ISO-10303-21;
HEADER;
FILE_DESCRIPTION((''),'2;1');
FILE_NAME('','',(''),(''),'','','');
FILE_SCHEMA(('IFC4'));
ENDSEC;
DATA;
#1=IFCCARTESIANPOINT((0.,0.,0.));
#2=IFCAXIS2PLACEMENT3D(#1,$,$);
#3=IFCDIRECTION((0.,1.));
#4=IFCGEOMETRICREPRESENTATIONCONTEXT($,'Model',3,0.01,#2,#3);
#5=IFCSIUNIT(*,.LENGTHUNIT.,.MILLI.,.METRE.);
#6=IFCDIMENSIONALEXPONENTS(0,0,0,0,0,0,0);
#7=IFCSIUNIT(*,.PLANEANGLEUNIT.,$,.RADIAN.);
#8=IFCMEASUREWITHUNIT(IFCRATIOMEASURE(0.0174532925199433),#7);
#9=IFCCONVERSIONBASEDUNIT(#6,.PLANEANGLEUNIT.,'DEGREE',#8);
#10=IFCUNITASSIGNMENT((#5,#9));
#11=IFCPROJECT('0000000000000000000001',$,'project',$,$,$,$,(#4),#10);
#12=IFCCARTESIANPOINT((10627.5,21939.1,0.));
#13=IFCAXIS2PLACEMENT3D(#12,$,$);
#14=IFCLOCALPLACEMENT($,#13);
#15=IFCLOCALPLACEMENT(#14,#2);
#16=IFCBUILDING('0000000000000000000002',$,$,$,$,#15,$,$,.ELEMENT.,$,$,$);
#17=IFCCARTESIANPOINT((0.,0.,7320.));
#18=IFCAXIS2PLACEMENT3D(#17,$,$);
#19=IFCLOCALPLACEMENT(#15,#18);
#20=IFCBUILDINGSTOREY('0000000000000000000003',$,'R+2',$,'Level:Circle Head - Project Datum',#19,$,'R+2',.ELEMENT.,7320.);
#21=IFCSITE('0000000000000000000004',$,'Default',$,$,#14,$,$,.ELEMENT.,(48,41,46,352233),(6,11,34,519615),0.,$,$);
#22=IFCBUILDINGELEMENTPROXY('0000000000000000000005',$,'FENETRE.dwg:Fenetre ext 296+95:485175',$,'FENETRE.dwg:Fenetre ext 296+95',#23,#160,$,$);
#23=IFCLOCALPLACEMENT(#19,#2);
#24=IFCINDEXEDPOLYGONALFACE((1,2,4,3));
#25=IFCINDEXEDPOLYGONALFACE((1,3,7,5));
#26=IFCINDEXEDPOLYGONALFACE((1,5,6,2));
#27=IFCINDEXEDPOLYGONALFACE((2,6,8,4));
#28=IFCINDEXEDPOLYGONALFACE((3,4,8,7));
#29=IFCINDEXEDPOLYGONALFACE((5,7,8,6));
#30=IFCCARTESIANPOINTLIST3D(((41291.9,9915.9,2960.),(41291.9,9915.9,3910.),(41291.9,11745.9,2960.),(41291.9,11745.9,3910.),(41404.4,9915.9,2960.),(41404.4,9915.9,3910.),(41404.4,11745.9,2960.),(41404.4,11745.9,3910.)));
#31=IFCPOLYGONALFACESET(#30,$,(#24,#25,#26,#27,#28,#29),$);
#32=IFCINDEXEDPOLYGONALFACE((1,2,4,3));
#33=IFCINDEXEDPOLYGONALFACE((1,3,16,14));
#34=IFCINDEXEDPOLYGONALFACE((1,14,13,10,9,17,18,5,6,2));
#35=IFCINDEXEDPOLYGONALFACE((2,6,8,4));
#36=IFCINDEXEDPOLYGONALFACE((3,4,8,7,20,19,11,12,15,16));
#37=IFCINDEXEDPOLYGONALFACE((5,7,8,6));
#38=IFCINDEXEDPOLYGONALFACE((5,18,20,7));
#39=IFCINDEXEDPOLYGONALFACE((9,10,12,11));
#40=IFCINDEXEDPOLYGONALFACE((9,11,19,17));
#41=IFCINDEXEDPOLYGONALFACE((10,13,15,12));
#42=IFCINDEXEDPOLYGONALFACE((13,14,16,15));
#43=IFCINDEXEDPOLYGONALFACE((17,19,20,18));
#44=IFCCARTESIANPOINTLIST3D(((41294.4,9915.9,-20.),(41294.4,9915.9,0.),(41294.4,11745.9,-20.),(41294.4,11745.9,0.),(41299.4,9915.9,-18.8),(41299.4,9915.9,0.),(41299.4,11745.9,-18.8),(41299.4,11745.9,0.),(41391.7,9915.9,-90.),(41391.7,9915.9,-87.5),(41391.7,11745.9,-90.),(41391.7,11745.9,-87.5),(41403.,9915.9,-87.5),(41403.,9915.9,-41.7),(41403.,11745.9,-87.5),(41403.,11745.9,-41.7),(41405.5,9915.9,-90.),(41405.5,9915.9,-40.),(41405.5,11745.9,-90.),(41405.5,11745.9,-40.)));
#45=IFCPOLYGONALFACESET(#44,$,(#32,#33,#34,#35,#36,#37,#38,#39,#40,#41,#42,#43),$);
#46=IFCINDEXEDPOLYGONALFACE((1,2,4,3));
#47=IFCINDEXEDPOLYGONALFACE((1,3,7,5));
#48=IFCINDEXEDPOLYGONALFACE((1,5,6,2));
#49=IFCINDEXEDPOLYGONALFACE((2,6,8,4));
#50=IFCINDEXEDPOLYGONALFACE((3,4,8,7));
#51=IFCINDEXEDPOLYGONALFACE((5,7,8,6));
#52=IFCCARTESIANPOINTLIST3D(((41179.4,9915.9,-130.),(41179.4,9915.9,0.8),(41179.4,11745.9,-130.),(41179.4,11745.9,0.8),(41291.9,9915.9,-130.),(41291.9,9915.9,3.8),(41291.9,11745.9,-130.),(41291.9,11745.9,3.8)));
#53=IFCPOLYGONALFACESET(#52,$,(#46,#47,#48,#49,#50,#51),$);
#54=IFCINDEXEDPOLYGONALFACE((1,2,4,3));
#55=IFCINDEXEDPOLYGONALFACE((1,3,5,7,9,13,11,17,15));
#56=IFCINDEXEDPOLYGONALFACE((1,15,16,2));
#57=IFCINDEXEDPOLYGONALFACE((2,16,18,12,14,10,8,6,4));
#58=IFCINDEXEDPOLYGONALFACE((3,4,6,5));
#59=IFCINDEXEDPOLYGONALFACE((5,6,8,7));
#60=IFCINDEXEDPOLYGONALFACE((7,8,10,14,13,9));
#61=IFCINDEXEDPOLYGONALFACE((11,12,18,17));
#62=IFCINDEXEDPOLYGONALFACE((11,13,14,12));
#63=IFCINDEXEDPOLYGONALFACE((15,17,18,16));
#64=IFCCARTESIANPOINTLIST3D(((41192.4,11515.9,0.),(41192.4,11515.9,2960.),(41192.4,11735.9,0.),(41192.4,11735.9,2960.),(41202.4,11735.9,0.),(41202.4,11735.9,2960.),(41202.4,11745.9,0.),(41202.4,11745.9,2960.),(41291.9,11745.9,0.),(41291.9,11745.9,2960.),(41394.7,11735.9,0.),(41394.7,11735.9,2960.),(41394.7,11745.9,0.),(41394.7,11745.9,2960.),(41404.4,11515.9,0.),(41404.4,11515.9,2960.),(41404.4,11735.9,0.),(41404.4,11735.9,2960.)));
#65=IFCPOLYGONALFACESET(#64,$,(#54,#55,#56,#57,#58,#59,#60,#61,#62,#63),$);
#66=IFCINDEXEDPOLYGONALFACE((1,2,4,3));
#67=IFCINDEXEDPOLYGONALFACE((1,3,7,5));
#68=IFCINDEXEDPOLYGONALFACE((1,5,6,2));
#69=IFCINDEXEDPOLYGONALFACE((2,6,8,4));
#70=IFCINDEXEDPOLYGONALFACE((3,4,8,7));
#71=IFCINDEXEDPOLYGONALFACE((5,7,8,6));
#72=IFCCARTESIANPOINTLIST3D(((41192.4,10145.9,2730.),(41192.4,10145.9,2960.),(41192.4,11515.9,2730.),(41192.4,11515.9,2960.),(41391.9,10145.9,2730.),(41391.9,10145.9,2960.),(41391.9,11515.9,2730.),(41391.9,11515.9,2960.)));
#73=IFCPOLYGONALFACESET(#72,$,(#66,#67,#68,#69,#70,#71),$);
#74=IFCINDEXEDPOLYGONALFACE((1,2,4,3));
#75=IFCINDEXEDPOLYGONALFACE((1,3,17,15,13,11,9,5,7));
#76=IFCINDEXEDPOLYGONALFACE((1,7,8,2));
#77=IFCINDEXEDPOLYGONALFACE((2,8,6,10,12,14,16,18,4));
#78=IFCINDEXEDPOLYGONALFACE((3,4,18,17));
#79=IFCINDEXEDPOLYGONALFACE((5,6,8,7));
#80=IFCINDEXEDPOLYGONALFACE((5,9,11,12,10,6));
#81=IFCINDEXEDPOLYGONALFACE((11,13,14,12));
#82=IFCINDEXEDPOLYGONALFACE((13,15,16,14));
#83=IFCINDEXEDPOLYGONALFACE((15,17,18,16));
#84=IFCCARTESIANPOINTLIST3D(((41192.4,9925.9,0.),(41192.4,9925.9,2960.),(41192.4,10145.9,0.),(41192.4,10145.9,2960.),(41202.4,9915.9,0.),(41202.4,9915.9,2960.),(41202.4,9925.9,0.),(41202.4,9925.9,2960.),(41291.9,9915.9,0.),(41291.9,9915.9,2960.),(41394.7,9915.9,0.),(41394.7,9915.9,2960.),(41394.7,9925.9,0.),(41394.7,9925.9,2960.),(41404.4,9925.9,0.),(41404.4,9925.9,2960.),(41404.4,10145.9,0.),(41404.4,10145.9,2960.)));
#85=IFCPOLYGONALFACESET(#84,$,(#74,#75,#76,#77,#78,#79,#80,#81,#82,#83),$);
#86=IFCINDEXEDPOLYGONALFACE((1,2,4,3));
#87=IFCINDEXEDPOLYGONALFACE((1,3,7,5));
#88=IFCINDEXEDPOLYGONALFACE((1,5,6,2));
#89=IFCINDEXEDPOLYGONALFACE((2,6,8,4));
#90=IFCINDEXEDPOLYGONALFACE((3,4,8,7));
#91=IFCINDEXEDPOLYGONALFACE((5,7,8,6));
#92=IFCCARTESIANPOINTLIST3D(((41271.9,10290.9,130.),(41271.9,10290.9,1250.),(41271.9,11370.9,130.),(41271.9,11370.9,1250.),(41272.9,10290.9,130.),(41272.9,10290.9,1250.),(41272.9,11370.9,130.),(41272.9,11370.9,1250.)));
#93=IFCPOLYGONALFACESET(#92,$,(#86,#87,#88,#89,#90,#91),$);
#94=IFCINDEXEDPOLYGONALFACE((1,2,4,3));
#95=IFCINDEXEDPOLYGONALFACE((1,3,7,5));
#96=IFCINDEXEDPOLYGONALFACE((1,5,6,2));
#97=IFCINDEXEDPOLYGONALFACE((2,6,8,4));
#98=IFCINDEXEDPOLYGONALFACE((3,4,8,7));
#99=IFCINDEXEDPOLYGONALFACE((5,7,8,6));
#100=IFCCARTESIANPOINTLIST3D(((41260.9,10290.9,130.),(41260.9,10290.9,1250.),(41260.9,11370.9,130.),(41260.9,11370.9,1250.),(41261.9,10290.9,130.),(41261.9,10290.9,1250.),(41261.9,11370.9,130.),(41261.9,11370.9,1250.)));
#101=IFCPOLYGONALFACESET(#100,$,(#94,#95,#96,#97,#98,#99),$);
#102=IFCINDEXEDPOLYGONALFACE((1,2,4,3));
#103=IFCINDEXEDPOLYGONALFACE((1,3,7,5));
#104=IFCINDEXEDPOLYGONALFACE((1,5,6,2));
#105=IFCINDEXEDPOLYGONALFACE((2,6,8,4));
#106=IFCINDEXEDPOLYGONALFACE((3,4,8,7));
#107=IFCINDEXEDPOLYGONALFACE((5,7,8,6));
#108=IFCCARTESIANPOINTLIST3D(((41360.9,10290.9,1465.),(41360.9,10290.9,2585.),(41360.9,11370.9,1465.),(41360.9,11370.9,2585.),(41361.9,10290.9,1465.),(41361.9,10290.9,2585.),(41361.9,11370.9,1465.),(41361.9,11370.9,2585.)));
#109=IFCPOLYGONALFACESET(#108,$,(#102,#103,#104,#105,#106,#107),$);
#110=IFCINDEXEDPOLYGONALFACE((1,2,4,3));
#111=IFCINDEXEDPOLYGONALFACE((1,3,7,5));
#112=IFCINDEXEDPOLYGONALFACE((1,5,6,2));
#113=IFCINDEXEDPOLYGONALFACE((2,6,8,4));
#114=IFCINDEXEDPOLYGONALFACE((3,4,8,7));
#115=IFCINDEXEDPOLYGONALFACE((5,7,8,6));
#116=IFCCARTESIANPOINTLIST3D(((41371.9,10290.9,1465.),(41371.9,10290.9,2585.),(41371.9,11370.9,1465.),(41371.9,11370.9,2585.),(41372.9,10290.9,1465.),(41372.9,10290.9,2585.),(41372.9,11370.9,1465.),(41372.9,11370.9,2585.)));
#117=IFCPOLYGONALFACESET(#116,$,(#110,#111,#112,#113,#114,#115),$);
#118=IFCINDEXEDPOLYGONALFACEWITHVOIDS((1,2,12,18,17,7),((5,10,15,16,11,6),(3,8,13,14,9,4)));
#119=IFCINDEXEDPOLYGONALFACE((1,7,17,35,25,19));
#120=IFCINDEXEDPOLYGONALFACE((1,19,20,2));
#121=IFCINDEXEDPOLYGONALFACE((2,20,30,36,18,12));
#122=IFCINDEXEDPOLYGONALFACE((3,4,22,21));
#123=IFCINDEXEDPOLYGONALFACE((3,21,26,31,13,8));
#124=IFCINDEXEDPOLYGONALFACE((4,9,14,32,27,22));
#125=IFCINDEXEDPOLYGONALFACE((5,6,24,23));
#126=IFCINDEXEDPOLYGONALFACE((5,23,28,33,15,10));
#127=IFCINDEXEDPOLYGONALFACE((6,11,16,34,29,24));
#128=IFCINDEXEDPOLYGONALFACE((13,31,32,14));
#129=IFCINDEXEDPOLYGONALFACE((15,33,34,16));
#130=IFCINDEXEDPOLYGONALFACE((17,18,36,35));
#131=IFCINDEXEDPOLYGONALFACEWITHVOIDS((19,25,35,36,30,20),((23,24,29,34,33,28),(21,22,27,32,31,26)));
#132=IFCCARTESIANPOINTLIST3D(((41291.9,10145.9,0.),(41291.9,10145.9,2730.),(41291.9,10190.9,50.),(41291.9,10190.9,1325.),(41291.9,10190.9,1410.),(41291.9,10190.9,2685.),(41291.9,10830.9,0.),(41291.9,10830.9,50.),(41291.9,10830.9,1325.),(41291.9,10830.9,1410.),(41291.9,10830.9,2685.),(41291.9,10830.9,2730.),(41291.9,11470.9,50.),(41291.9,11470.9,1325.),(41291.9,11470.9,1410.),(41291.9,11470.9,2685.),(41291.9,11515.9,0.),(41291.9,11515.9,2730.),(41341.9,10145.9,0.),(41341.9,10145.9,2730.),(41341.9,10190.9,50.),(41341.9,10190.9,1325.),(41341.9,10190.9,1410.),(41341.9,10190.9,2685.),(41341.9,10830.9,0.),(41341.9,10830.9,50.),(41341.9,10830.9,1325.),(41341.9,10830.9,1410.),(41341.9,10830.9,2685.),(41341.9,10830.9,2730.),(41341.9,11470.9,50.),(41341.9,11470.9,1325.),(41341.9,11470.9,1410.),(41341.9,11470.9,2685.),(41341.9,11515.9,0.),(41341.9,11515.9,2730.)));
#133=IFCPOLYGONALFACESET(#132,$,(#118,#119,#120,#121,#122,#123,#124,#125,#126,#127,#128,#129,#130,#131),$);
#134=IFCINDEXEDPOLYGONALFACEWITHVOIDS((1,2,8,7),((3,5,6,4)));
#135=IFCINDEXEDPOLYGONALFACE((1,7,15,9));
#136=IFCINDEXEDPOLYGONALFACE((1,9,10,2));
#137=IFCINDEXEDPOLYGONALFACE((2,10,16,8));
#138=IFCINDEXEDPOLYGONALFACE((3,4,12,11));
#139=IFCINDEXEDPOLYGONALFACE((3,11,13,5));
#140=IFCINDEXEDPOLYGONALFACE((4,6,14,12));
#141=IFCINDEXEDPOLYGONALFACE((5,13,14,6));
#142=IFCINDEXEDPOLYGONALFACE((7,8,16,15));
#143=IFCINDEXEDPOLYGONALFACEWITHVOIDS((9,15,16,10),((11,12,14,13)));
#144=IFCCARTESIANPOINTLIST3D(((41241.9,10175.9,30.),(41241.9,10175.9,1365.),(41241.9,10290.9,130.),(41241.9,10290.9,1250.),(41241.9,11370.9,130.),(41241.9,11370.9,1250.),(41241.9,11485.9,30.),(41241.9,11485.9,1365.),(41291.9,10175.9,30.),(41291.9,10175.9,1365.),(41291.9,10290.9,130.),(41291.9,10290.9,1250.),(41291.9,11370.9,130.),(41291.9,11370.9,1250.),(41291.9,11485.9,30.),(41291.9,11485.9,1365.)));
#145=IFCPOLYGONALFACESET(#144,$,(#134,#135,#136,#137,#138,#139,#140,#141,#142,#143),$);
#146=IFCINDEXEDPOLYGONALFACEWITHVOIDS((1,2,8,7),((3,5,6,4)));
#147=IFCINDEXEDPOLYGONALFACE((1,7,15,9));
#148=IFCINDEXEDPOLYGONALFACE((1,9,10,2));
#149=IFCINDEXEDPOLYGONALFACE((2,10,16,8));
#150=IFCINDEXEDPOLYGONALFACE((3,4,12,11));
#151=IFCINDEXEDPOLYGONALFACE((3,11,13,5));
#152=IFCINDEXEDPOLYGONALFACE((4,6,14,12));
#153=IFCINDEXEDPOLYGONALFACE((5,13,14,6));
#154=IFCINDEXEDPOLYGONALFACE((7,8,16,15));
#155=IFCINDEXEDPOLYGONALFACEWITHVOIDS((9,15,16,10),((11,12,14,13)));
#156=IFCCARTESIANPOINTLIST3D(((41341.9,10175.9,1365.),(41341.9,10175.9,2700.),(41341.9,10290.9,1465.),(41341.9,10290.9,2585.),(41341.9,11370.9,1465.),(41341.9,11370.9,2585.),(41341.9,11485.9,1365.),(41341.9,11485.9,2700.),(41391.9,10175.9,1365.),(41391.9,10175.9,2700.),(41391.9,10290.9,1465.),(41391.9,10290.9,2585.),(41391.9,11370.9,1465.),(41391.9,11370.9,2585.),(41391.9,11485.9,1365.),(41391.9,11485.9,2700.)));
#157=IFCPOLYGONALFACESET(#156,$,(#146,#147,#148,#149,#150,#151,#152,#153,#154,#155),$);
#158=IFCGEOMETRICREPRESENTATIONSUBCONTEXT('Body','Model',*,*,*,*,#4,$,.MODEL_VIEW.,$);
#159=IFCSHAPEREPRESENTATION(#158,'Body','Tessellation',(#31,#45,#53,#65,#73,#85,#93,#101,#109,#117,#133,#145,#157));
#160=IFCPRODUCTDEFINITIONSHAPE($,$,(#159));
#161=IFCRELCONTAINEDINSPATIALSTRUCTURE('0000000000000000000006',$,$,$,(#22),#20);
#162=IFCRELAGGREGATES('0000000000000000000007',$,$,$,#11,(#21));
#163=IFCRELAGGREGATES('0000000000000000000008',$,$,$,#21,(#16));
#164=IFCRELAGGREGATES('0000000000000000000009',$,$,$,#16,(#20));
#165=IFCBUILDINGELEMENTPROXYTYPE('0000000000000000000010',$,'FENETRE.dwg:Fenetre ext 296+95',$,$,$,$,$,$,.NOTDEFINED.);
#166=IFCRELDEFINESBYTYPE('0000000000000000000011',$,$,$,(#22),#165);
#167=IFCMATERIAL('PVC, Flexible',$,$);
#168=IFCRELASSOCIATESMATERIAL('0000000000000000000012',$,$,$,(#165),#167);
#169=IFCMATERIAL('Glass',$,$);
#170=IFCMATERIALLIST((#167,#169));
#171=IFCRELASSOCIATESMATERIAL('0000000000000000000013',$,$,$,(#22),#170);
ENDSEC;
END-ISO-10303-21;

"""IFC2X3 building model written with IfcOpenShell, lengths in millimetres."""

from ifc_helpers import new_model, entity, si_unit, converted_unit, direction, frame, frame_2d, origin, origin_2d_with_axis, place, context, subcontext, project, spatial, polyline, rectangle, outline, extrude, source, transform, mapped, material, material_list, type_object, type_shapes, element, save


model = new_model("IFC2X3")

# Units and contexts
model_context = context("Model", 3, precision=0.01, world=origin(), true_north=direction((0.0, 1.0)))
body_context = subcontext(model_context, "Body", "Model", "MODEL_VIEW")
ifc_project = project(units=[si_unit("LENGTHUNIT", "METRE", prefix="MILLI"), converted_unit("PLANEANGLEUNIT", "DEGREE", entity("IfcRatioMeasure", 0.0174532925199433), si_unit("PLANEANGLEUNIT", "RADIAN"), dimensions=[0, 0, 0, 0, 0, 0, 0])], contexts=[model_context])

# Site, building, storey
site_placement = place(None, frame((10627.5, 21939.1, 0.0)))
site = spatial("IfcSite", under=ifc_project, at=site_placement, Name="Default", CompositionType="ELEMENT", RefLatitude=(48, 41, 46, 352233), RefLongitude=(6, 11, 34, 519615), RefElevation=0.0)
building_placement = place(site_placement, origin())
building = spatial("IfcBuilding", under=site, at=building_placement, CompositionType="ELEMENT")
storey_placement = place(building_placement, frame((0.0, 0.0, 7320.0)))
storey = spatial("IfcBuildingStorey", under=building, at=storey_placement, Name="R+2", ObjectType="Level:Circle Head - Project Datum", LongName="R+2", CompositionType="ELEMENT", Elevation=7320.0)

# Building element proxy
ifc_material_1 = material(Name="PVC, Flexible")
ifc_material_2 = material(Name="Glass")
building_element_proxy_type_1 = type_object("IfcBuildingElementProxyType", Name="FENETRE.dwg:Fenetre ext 296+95", PredefinedType="NOTDEFINED", material=ifc_material_1)
shared_shape_1 = source(origin(), body_context, "Body", "SweptSolid", [
    extrude(rectangle(XDim=112.5, YDim=1830.0, at=origin_2d_with_axis()), frame((-10.4, -56.3, 2960.0), z_axis=(0.0, 0.0, 1.0), x_axis=(0.0, 1.0, 0.0)), (0.0, 0.0, 1.0), 950.0),
    extrude(outline(polyline([(27.5, -64.4), (47.5, -64.4), (47.5, -59.4), (28.8, -59.4), (7.5, 46.7), (-42.5, 46.7), (-42.5, 32.9), (-40.0, 32.9), (-40.0, 44.2), (5.8, 44.2), (27.5, -64.4)])), frame((-925.4, -66.9, -47.5), z_axis=(1.0, 0.0, 0.0), x_axis=(0.0, 0.0, 1.0)), (0.0, 0.0, 1.0), 1830.0),
    extrude(outline(polyline([(-54.5, -66.1), (58.0, -66.1), (54.5, 67.6), (-58.0, 64.6), (-54.5, -66.1)])), frame((-925.4, 56.3, -63.8), z_axis=(1.0, 0.0, 0.0), x_axis=(0.0, -0.999645, 0.02665)), (0.0, 0.0, 1.0), 1830.0),
    extrude(outline(polyline([(-97.0, -55.6), (5.9, -55.6), (95.4, -55.6), (95.4, -45.6), (105.4, -45.6), (105.4, 174.4), (-106.6, 174.4), (-106.6, -45.6), (-97.0, -45.6), (-97.0, -55.6)])), frame((849.0, -5.9, 0.0), z_axis=(0.0, 0.0, 1.0), x_axis=(0.0, 1.0, 0.0)), (0.0, 0.0, 1.0), 2960.0),
    extrude(rectangle(XDim=1370.0, YDim=199.5, at=origin_2d_with_axis()), frame((-10.4, -0.3, 2730.0), z_axis=(0.0, 0.0, 1.0), x_axis=(-1.0, 0.0, 0.0)), (0.0, 0.0, 1.0), 230.0),
    extrude(outline(polyline([(-55.6, 97.0), (-55.6, -5.9), (-55.6, -95.4), (-45.6, -95.4), (-45.6, -105.4), (174.4, -105.4), (174.4, 106.6), (-45.6, 106.6), (-45.6, 97.0), (-55.6, 97.0)])), frame((-869.9, -5.9, 0.0), z_axis=(0.0, 0.0, -1.0), x_axis=(1.0, 0.0, 0.0)), (0.0, 0.0, -1.0), 2960.0),
    extrude(rectangle(XDim=1080.0, YDim=1.0, at=origin_2d_with_axis()), frame((-10.4, 19.5, 130.0), z_axis=(0.0, 0.0, 1.0), x_axis=(-1.0, 0.0, 0.0)), (0.0, 0.0, 1.0), 1120.0),
    extrude(rectangle(XDim=1080.0, YDim=1.0, at=origin_2d_with_axis()), frame((-10.4, 30.5, 130.0), z_axis=(0.0, 0.0, 1.0), x_axis=(-1.0, 0.0, 0.0)), (0.0, 0.0, 1.0), 1120.0),
    extrude(rectangle(XDim=1080.0, YDim=1.0, at=frame_2d((0.0, 0.0), x_axis=(1.0, 0.0))), frame((-10.4, -69.5, 1465.0), z_axis=(0.0, 0.0, 1.0), x_axis=(-1.0, 0.0, 0.0)), (0.0, 0.0, 1.0), 1120.0),
    extrude(rectangle(XDim=1080.0, YDim=1.0, at=frame_2d((0.0, 0.0), x_axis=(1.0, 0.0))), frame((-10.4, -80.5, 1465.0), z_axis=(0.0, 0.0, 1.0), x_axis=(-1.0, 0.0, 0.0)), (0.0, 0.0, 1.0), 1120.0),
    extrude(outline(polyline([(-685.0, -1365.0), (0.0, -1365.0), (685.0, -1365.0), (685.0, 1365.0), (0.0, 1365.0), (-685.0, 1365.0), (-685.0, -1365.0)]), holes=[polyline([(-640.0, -1320.0), (-640.0, -45.0), (0.0, -45.0), (640.0, -45.0), (640.0, -1320.0), (0.0, -1320.0), (-640.0, -1320.0)]), polyline([(-640.0, 40.0), (-640.0, 1315.0), (0.0, 1315.0), (640.0, 1315.0), (640.0, 40.0), (0.0, 40.0), (-640.0, 40.0)])]), frame((-10.4, -50.0, 1365.0), z_axis=(0.0, 1.0, 0.0), x_axis=(1.0, 0.0, 0.0)), (0.0, 0.0, 1.0), 50.0),
    extrude(outline(polyline([(-655.0, -667.5), (655.0, -667.5), (655.0, 667.5), (-655.0, 667.5), (-655.0, -667.5)]), holes=[polyline([(-540.0, 552.5), (540.0, 552.5), (540.0, -567.5), (-540.0, -567.5), (-540.0, 552.5)])]), frame((-10.4, 0.0, 697.5), z_axis=(0.0, 1.0, 0.0), x_axis=(-1.0, 0.0, 0.0)), (0.0, 0.0, 1.0), 50.0),
    extrude(outline(polyline([(-655.0, -667.5), (655.0, -667.5), (655.0, 667.5), (-655.0, 667.5), (-655.0, -667.5)]), holes=[polyline([(-540.0, 552.5), (540.0, 552.5), (540.0, -567.5), (-540.0, -567.5), (-540.0, 552.5)])]), frame((-10.4, -100.0, 2032.5), z_axis=(0.0, 1.0, 0.0), x_axis=(-1.0, 0.0, 0.0)), (0.0, 0.0, 1.0), 50.0),
])
type_shapes(building_element_proxy_type_1, [shared_shape_1])
ifc_material_list_1 = material_list([ifc_material_1, ifc_material_2])
proxy_1_placement = place(storey_placement, frame((41291.9, 10841.3, 0.0), z_axis=(0.0, 0.0, 1.0), x_axis=(0.0, 1.0, 0.0)))
element("IfcBuildingElementProxy", 1, at=proxy_1_placement, inside=storey, type_object=building_element_proxy_type_1, material=ifc_material_list_1, Name="FENETRE.dwg:Fenetre ext 296+95:485175", ObjectType="FENETRE.dwg:Fenetre ext 296+95", context=body_context, shape_type="MappedRepresentation", body=[
    mapped(shared_shape_1, transform((0.0, 0.0, 0.0), scale=1.0)),
])

save(model, "model.ifc")
